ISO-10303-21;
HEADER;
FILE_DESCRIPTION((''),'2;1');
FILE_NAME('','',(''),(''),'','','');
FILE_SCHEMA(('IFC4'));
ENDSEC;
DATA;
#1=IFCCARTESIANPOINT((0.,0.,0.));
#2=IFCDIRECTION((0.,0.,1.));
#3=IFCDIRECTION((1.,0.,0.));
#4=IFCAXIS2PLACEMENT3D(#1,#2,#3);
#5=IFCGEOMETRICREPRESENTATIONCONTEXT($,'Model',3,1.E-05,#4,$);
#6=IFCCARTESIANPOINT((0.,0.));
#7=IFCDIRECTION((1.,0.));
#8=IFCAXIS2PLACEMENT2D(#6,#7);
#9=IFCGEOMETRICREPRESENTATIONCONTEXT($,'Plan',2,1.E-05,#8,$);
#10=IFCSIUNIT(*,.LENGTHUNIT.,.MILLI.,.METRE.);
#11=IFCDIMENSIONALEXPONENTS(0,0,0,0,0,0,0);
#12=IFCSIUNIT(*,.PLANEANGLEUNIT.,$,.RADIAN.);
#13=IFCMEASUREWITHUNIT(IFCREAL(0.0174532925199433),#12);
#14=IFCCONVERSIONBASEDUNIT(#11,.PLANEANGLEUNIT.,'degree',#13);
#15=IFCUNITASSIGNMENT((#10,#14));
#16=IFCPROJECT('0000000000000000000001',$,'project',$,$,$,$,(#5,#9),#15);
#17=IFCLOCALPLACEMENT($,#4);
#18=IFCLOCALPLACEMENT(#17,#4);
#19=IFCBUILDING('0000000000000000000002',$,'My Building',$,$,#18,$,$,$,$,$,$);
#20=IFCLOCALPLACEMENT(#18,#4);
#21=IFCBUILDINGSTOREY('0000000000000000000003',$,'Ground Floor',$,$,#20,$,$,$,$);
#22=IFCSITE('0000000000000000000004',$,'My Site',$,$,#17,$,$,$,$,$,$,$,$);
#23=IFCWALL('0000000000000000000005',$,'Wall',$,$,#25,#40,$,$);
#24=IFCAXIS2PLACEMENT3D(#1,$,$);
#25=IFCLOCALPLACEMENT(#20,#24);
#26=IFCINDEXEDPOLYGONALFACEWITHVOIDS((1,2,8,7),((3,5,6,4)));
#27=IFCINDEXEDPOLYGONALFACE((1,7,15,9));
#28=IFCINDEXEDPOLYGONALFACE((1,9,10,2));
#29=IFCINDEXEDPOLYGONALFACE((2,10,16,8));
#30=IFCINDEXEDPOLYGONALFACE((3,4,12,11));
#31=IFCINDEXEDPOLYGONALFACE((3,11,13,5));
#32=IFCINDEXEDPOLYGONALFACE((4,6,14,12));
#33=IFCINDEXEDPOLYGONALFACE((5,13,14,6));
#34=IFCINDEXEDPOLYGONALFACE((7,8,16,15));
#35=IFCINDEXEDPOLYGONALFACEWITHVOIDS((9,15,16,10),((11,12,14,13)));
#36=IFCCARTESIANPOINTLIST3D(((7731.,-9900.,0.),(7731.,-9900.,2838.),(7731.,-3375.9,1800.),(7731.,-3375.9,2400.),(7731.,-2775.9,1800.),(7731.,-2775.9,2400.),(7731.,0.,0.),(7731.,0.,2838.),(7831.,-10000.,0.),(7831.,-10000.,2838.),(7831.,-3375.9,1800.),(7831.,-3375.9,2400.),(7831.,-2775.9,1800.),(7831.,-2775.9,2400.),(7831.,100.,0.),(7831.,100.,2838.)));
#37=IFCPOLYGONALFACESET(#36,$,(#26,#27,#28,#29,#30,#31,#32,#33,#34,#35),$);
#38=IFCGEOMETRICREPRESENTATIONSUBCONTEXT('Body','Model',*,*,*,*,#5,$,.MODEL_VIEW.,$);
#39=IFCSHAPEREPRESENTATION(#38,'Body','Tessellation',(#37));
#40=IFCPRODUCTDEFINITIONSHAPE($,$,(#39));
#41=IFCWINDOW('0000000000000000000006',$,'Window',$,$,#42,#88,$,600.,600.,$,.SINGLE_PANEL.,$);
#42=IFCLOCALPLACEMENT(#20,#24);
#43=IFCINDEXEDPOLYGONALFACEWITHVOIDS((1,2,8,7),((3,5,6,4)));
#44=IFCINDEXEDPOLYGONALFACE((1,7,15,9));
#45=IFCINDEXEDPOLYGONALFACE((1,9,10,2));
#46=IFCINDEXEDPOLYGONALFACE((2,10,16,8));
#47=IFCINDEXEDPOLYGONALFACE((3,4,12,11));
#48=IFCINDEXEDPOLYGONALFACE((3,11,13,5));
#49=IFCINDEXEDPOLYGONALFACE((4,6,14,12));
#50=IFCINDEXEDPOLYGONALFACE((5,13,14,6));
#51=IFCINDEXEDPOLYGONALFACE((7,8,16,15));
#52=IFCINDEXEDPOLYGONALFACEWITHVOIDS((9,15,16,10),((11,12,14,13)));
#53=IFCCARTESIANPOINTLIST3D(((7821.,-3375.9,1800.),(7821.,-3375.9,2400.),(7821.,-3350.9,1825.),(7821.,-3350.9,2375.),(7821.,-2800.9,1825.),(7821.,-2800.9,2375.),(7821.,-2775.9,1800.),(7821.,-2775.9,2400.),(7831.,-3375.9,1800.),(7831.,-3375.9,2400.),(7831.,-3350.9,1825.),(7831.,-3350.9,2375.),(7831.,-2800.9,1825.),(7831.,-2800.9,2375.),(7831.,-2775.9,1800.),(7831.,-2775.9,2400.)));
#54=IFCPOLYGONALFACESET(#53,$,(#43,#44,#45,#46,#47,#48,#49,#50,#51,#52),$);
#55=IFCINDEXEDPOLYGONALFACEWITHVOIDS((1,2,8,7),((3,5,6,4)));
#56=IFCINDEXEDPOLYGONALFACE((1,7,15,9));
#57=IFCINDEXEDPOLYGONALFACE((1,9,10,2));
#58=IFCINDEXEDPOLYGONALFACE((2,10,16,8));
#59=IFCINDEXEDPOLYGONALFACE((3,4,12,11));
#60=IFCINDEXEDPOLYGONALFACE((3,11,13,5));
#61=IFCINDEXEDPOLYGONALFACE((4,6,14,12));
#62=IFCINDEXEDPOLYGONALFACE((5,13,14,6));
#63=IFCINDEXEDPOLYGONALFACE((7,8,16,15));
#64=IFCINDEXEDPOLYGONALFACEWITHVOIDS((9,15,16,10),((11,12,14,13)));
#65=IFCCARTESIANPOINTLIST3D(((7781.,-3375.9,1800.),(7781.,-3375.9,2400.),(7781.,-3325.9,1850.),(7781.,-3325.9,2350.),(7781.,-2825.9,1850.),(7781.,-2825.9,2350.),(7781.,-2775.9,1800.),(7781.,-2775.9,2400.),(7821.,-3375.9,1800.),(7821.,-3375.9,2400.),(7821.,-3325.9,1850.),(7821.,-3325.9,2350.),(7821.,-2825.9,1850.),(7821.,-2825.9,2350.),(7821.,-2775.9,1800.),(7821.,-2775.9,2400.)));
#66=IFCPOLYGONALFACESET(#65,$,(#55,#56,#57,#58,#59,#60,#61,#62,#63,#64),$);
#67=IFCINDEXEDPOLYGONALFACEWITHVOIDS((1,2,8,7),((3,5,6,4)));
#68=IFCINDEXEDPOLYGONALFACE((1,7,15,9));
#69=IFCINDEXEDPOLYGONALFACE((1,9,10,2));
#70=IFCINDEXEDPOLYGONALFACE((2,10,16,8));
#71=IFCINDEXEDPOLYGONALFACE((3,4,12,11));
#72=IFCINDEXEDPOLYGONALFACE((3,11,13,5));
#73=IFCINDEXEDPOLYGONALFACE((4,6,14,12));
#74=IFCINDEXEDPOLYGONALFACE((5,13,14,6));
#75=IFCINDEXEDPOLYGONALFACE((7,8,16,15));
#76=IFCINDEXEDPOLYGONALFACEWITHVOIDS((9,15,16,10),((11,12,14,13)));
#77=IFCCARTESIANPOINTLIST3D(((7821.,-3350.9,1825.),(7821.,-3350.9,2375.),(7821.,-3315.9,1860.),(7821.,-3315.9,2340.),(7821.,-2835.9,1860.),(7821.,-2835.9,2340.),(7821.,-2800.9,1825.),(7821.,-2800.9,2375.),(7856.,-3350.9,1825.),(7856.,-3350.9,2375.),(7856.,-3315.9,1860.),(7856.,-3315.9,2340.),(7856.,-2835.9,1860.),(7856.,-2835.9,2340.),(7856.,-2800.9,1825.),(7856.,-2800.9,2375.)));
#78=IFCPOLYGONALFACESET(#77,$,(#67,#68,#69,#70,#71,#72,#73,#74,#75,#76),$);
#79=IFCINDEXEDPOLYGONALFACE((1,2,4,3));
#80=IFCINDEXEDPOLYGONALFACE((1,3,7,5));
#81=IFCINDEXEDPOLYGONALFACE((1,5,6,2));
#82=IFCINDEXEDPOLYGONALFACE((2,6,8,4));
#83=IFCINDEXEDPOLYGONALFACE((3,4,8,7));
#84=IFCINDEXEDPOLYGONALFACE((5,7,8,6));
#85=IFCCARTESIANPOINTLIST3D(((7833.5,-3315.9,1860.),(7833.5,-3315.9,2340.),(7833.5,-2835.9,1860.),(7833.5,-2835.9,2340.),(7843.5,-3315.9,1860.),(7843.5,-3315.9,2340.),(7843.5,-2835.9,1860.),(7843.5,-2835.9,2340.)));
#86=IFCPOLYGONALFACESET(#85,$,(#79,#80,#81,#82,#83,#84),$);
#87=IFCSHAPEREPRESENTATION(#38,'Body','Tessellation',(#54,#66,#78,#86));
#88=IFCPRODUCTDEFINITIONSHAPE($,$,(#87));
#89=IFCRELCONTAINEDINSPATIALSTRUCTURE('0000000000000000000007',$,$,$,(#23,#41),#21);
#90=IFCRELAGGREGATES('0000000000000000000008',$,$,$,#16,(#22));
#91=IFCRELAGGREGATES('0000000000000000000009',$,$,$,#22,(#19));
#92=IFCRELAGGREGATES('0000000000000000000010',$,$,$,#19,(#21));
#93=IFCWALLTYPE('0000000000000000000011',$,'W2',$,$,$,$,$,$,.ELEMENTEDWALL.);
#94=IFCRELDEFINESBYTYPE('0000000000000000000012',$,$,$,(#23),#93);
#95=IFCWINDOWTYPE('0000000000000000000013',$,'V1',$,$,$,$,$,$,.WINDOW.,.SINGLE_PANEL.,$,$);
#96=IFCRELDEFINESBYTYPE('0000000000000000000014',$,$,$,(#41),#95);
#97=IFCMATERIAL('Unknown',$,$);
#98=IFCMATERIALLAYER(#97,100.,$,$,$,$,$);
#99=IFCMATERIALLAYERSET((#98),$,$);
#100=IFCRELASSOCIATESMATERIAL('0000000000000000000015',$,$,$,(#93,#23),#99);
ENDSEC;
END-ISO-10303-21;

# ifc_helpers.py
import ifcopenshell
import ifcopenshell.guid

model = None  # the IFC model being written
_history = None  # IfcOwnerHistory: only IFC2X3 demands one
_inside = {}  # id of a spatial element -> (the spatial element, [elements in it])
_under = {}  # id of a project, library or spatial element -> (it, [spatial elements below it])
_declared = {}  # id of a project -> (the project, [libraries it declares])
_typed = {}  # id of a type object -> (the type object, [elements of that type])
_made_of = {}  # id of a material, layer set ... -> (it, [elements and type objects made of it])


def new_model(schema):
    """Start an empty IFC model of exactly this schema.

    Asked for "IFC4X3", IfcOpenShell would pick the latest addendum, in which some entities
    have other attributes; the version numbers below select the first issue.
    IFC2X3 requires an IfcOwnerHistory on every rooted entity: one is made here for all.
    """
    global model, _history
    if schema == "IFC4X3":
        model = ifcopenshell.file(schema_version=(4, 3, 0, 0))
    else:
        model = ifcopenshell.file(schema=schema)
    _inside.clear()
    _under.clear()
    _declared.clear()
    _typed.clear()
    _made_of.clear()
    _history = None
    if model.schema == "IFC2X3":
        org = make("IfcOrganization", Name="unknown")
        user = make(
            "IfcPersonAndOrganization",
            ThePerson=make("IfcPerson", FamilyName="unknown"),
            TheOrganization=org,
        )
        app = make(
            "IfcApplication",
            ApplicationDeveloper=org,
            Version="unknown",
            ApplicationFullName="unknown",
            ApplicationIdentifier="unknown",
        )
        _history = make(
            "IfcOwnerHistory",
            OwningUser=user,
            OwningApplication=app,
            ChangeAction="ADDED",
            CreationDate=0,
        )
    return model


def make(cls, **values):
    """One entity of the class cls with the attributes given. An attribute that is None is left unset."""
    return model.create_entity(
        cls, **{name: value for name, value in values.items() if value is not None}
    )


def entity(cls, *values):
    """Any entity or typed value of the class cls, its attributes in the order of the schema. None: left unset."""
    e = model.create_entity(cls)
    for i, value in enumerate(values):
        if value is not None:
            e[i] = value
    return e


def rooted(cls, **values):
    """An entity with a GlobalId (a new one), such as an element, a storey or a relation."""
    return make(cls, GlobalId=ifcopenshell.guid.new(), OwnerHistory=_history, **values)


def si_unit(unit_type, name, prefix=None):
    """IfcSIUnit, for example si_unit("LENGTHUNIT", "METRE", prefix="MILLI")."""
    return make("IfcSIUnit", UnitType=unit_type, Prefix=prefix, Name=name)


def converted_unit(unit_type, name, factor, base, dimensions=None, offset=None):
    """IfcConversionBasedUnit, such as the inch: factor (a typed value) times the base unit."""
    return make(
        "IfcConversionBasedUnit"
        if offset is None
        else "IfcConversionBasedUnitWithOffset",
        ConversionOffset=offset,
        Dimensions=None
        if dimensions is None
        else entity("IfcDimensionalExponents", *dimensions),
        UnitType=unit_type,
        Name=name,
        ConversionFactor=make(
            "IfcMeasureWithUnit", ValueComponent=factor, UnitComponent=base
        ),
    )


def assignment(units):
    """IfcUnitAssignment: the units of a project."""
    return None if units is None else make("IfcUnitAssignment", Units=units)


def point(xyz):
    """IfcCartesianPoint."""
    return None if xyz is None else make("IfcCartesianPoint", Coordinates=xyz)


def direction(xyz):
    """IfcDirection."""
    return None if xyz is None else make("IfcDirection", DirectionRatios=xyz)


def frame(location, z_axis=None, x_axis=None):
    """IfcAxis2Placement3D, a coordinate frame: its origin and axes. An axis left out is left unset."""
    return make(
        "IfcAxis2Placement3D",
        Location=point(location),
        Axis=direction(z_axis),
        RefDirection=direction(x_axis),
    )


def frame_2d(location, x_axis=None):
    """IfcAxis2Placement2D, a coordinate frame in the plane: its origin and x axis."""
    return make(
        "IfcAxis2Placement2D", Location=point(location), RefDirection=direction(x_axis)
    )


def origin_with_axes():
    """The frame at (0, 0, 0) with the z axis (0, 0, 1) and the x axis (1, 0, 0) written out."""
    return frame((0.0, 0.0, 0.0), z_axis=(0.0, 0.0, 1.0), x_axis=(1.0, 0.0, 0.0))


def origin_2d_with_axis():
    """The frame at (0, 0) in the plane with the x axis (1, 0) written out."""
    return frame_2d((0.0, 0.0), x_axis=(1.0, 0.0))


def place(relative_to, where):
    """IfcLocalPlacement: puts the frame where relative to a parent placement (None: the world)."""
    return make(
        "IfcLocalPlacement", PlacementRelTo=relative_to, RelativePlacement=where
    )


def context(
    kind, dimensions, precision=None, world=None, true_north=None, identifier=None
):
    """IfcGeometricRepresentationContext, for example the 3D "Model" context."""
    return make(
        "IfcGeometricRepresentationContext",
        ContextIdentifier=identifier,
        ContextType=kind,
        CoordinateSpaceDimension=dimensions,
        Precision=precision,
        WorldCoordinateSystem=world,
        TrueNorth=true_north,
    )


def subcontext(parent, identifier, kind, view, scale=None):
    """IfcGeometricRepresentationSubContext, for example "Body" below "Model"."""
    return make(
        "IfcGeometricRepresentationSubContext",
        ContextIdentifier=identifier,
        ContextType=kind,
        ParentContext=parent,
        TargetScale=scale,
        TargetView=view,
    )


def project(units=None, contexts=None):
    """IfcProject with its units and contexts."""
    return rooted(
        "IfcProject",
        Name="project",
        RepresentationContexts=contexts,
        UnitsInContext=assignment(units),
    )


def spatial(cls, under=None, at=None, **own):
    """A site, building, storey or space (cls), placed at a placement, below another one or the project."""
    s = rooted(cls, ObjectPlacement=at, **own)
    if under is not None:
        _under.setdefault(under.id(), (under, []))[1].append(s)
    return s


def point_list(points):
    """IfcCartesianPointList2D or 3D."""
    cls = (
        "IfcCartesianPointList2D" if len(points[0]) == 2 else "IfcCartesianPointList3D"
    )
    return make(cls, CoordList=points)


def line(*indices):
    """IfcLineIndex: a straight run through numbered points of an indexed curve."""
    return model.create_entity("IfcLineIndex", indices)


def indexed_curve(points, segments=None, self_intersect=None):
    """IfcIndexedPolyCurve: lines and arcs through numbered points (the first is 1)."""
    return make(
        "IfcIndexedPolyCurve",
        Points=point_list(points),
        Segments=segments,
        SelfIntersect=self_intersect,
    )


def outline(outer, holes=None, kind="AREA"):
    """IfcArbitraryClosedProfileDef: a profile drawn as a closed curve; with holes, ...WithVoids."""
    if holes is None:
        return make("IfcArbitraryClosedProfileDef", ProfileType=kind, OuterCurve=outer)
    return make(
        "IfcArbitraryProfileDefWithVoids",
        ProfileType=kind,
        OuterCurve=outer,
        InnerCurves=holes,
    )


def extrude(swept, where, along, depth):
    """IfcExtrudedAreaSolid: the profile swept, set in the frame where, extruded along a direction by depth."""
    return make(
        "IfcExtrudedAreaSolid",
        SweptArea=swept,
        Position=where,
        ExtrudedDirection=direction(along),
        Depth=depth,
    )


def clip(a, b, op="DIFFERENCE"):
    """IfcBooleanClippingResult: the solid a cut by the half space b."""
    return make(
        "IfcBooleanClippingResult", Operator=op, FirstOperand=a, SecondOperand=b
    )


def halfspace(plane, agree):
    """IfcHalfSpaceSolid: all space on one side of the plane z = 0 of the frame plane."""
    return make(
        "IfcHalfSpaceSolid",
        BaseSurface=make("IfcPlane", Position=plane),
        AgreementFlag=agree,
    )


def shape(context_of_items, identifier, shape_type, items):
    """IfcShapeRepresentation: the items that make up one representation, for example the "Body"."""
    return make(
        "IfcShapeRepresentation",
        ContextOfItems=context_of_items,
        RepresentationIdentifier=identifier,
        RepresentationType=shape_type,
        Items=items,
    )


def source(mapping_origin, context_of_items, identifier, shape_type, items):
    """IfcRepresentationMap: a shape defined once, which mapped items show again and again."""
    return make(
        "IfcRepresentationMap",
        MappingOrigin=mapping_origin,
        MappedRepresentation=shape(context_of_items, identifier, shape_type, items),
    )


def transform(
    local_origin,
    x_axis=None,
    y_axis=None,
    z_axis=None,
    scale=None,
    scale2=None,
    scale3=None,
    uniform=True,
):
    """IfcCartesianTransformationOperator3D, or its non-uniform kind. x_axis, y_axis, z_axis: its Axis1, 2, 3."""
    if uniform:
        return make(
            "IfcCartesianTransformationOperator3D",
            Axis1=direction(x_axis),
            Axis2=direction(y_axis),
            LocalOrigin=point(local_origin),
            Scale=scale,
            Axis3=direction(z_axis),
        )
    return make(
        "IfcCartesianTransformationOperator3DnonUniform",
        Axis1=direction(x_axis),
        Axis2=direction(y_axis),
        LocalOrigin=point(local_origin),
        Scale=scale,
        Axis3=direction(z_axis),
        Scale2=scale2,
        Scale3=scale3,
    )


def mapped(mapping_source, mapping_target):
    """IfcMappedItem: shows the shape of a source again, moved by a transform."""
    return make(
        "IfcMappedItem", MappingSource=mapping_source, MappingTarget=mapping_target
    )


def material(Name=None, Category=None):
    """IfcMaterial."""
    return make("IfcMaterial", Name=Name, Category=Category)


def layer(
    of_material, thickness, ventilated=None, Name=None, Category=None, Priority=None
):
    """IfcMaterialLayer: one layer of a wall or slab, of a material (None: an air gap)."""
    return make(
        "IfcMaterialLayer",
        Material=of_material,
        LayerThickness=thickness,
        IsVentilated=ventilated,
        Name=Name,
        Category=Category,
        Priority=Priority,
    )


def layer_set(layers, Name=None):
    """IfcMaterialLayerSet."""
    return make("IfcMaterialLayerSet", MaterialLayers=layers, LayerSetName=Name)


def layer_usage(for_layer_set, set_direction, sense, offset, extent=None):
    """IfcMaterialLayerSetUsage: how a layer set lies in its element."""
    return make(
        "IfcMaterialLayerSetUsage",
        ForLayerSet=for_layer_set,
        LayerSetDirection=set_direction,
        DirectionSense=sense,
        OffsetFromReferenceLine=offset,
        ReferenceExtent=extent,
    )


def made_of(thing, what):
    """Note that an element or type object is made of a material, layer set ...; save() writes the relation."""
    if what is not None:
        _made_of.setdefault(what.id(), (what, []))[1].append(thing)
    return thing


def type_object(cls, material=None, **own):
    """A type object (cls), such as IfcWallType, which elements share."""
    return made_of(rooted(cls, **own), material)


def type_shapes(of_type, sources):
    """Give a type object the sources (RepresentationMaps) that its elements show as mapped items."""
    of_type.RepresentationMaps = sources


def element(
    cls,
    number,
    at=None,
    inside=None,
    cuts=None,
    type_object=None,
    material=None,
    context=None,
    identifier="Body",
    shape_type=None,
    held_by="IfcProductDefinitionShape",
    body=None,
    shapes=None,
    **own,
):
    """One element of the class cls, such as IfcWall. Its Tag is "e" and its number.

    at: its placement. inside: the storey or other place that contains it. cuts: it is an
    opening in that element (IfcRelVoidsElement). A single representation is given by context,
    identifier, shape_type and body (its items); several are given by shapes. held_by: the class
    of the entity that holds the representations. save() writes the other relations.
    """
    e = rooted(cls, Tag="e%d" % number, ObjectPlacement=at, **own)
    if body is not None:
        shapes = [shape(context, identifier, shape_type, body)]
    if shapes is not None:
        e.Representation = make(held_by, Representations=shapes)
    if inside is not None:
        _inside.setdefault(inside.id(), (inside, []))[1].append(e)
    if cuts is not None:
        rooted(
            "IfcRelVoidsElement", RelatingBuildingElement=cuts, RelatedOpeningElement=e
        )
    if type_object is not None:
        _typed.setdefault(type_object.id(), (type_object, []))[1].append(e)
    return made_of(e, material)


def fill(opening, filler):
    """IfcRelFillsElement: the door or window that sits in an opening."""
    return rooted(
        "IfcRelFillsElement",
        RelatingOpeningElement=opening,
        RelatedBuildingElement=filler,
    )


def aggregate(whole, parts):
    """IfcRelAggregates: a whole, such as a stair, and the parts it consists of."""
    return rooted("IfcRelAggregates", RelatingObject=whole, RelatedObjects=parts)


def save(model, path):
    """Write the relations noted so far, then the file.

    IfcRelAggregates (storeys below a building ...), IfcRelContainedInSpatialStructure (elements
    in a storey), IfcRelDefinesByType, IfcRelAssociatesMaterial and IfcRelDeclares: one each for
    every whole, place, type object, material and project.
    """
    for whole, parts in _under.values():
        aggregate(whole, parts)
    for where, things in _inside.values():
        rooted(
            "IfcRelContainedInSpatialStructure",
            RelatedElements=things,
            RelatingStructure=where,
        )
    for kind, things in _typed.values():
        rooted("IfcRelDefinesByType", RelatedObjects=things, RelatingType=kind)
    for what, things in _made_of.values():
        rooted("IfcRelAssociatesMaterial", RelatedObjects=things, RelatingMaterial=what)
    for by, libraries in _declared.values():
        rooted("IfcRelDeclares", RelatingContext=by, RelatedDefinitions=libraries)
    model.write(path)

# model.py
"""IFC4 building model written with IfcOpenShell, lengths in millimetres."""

from ifc_helpers import new_model, entity, si_unit, converted_unit, frame, origin_with_axes, origin_2d_with_axis, place, context, subcontext, project, spatial, line, indexed_curve, outline, extrude, clip, halfspace, shape, source, transform, mapped, material, layer, layer_set, layer_usage, type_object, type_shapes, element, fill, save


model = new_model("IFC4")

# Units and contexts
model_context = context("Model", 3, precision=1e-05, world=origin_with_axes())
plan_context = context("Plan", 2, precision=1e-05, world=origin_2d_with_axis())
body_context_1 = subcontext(model_context, "Body", "Model", "MODEL_VIEW")
body_context_2 = subcontext(plan_context, "Body", "Plan", "PLAN_VIEW")
ifc_project = project(units=[si_unit("LENGTHUNIT", "METRE", prefix="MILLI"), converted_unit("PLANEANGLEUNIT", "degree", entity("IfcReal", 0.0174532925199433), si_unit("PLANEANGLEUNIT", "RADIAN"), dimensions=[0, 0, 0, 0, 0, 0, 0])], contexts=[model_context, plan_context])

# Site, building, storey
site_placement = place(None, origin_with_axes())
site = spatial("IfcSite", under=ifc_project, at=site_placement, Name="My Site")
building_placement = place(site_placement, origin_with_axes())
building = spatial("IfcBuilding", under=site, at=building_placement, Name="My Building")
storey_placement = place(building_placement, origin_with_axes())
storey = spatial("IfcBuildingStorey", under=building, at=storey_placement, Name="Ground Floor")

# Shared definitions
ifc_material = material(Name="Unknown")

# Wall, opening, window
ifc_layer_1 = layer(ifc_material, 100.0)
ifc_layer_set_1 = layer_set([ifc_layer_1])
wall_type = type_object("IfcWallType", Name="W2", PredefinedType="ELEMENTEDWALL", material=ifc_layer_set_1)
ifc_layer_usage_1 = layer_usage(ifc_layer_set_1, "AXIS2", "POSITIVE", 0.0)
wall_1_placement = place(storey_placement, frame((7831.0, -10000.0, 0.0), z_axis=(0.0, 0.0, 1.0), x_axis=(0.0, 1.0, 0.0)))
wall_1 = element("IfcWall", 1, at=wall_1_placement, inside=storey, type_object=wall_type, material=ifc_layer_usage_1, Name="Wall", context=body_context_1, shape_type="Clipping", body=[
    clip(clip(extrude(outline(indexed_curve([(0.0, 0.0), (0.0, 100.0), (10100.0, 100.0), (10100.0, 0.0), (0.0, 0.0)], self_intersect=False)), origin_with_axes(), (0.0, 0.0, 1.0), 2838.0), halfspace(frame((0.0, 0.0, 0.0), z_axis=(-0.707105, 0.707109, 0.0), x_axis=(0.707109, 0.707105, 0.0)), False)), halfspace(frame((10100.0, 0.0, 0.0), z_axis=(0.707107, 0.707107, 0.0), x_axis=(0.707107, -0.707107, 0.0)), False)),
])
shared_shape_1 = source(origin_with_axes(), body_context_1, "Body", "SolidModel", [
    extrude(outline(indexed_curve([(0.0, 0.0), (600.0, 0.0), (600.0, 600.0), (0.0, 600.0)], segments=[line(1, 2, 3, 4, 1)])), frame((0.0, -600.0, 0.0), z_axis=(0.0, -1.0, 0.0), x_axis=(1.0, 0.0, 0.0)), (0.0, 0.0, -1.0), 1200.0),
])
opening_1_placement = place(wall_1_placement, frame((7224.1, 100.0, 1800.0), z_axis=(0.0, 0.0, 1.0), x_axis=(-1.0, 0.0, 0.0)))
opening_1 = element("IfcOpeningElement", 2, at=opening_1_placement, cuts=wall_1, PredefinedType="OPENING", context=body_context_1, shape_type="MappedRepresentation", body=[
    mapped(shared_shape_1, transform((0.0, 0.0, 0.0), x_axis=(1.0, 0.0, 0.0), y_axis=(0.0, 1.0, 0.0), z_axis=(0.0, 0.0, 1.0), scale=1.0)),
])
window_type_1 = type_object("IfcWindowType", Name="V1", PartitioningType="SINGLE_PANEL", PredefinedType="WINDOW")
shared_shape_2 = source(origin_with_axes(), body_context_1, "Body", "SolidModel", [
    extrude(outline(indexed_curve([(0.0, 0.0), (600.0, 0.0), (600.0, 600.0), (0.0, 600.0)], segments=[line(1, 2, 3, 4, 1)]), holes=[indexed_curve([(25.0, 25.0), (575.0, 25.0), (575.0, 575.0), (25.0, 575.0)], segments=[line(1, 2, 3, 4, 1)])]), frame((0.0, 90.0, 0.0), z_axis=(0.0, -1.0, 0.0), x_axis=(1.0, 0.0, 0.0)), (0.0, 0.0, -1.0), 10.0),
    extrude(outline(indexed_curve([(0.0, 0.0), (600.0, 0.0), (600.0, 600.0), (0.0, 600.0)], segments=[line(1, 2, 3, 4, 1)]), holes=[indexed_curve([(50.0, 50.0), (550.0, 50.0), (550.0, 550.0), (50.0, 550.0)], segments=[line(1, 2, 3, 4, 1)])]), frame((0.0, 50.0, 0.0), z_axis=(0.0, -1.0, 0.0), x_axis=(1.0, 0.0, 0.0)), (0.0, 0.0, -1.0), 40.0),
    extrude(outline(indexed_curve([(0.0, 0.0), (550.0, 0.0), (550.0, 550.0), (0.0, 550.0)], segments=[line(1, 2, 3, 4, 1)]), holes=[indexed_curve([(35.0, 35.0), (515.0, 35.0), (515.0, 515.0), (35.0, 515.0)], segments=[line(1, 2, 3, 4, 1)])]), frame((25.0, 90.0, 25.0), z_axis=(0.0, -1.0, 0.0), x_axis=(1.0, 0.0, 0.0)), (0.0, 0.0, -1.0), 35.0),
    extrude(outline(indexed_curve([(35.0, 35.0), (515.0, 35.0), (515.0, 515.0), (35.0, 515.0)], segments=[line(1, 2, 3, 4, 1)])), frame((25.0, 102.5, 25.0), z_axis=(0.0, -1.0, 0.0), x_axis=(1.0, 0.0, 0.0)), (0.0, 0.0, -1.0), 10.0),
])
shared_shape_3 = source(origin_with_axes(), body_context_2, "Body", "Curve2D", [
    entity("IfcIndexedPolyCurve", entity("IfcCartesianPointList2D", [[50.0, 50.0], [550.0, 50.0]])),
    entity("IfcIndexedPolyCurve", entity("IfcCartesianPointList2D", [[0.0, 100.0], [25.0, 100.0], [25.0, 90.0], [50.0, 90.0], [50.0, 50.0], [0.0, 50.0]]), [entity("IfcLineIndex", [1, 2, 3, 4, 5, 6, 1])]),
    entity("IfcIndexedPolyCurve", entity("IfcCartesianPointList2D", [[600.0, 100.0], [575.0, 100.0], [575.0, 90.0], [550.0, 90.0], [550.0, 50.0], [600.0, 50.0]]), [entity("IfcLineIndex", [1, 2, 3, 4, 5, 6, 1])]),
    entity("IfcIndexedPolyCurve", entity("IfcCartesianPointList2D", [[25.0, 90.0], [60.0, 90.0], [60.0, 125.0], [25.0, 125.0]]), [entity("IfcLineIndex", [1, 2, 3, 4, 1])]),
    entity("IfcIndexedPolyCurve", entity("IfcCartesianPointList2D", [[575.0, 90.0], [540.0, 90.0], [540.0, 125.0], [575.0, 125.0]]), [entity("IfcLineIndex", [1, 2, 3, 4, 1])]),
    entity("IfcIndexedPolyCurve", entity("IfcCartesianPointList2D", [[60.0, 90.0], [540.0, 90.0]])),
    entity("IfcIndexedPolyCurve", entity("IfcCartesianPointList2D", [[60.0, 125.0], [540.0, 125.0]])),
    entity("IfcIndexedPolyCurve", entity("IfcCartesianPointList2D", [[60.0, 107.5], [540.0, 107.5]])),
])
type_shapes(window_type_1, [shared_shape_2, shared_shape_3])
window_1_placement = place(opening_1_placement, frame((0.0, 0.0, 0.0), z_axis=(0.0, 0.0, 1.0), x_axis=(1.0, 0.0, 0.0)))
window_1 = element("IfcWindow", 3, at=window_1_placement, inside=storey, type_object=window_type_1, Name="Window", OverallHeight=600.0, OverallWidth=600.0, PartitioningType="SINGLE_PANEL", shapes=[
    shape(body_context_1, "Body", "MappedRepresentation", [mapped(shared_shape_2, transform((0.0, 0.0, 0.0), x_axis=(1.0, 0.0, 0.0), y_axis=(0.0, 1.0, 0.0), z_axis=(0.0, 0.0, 1.0), scale=1.0))]),
    shape(body_context_2, "Body", "MappedRepresentation", [mapped(shared_shape_3, transform((0.0, 0.0, 0.0), x_axis=(1.0, 0.0, 0.0), y_axis=(0.0, 1.0, 0.0), z_axis=(0.0, 0.0, 1.0), scale=1.0))]),
])
fill(opening_1, window_1)

save(model, "model.ifc")
